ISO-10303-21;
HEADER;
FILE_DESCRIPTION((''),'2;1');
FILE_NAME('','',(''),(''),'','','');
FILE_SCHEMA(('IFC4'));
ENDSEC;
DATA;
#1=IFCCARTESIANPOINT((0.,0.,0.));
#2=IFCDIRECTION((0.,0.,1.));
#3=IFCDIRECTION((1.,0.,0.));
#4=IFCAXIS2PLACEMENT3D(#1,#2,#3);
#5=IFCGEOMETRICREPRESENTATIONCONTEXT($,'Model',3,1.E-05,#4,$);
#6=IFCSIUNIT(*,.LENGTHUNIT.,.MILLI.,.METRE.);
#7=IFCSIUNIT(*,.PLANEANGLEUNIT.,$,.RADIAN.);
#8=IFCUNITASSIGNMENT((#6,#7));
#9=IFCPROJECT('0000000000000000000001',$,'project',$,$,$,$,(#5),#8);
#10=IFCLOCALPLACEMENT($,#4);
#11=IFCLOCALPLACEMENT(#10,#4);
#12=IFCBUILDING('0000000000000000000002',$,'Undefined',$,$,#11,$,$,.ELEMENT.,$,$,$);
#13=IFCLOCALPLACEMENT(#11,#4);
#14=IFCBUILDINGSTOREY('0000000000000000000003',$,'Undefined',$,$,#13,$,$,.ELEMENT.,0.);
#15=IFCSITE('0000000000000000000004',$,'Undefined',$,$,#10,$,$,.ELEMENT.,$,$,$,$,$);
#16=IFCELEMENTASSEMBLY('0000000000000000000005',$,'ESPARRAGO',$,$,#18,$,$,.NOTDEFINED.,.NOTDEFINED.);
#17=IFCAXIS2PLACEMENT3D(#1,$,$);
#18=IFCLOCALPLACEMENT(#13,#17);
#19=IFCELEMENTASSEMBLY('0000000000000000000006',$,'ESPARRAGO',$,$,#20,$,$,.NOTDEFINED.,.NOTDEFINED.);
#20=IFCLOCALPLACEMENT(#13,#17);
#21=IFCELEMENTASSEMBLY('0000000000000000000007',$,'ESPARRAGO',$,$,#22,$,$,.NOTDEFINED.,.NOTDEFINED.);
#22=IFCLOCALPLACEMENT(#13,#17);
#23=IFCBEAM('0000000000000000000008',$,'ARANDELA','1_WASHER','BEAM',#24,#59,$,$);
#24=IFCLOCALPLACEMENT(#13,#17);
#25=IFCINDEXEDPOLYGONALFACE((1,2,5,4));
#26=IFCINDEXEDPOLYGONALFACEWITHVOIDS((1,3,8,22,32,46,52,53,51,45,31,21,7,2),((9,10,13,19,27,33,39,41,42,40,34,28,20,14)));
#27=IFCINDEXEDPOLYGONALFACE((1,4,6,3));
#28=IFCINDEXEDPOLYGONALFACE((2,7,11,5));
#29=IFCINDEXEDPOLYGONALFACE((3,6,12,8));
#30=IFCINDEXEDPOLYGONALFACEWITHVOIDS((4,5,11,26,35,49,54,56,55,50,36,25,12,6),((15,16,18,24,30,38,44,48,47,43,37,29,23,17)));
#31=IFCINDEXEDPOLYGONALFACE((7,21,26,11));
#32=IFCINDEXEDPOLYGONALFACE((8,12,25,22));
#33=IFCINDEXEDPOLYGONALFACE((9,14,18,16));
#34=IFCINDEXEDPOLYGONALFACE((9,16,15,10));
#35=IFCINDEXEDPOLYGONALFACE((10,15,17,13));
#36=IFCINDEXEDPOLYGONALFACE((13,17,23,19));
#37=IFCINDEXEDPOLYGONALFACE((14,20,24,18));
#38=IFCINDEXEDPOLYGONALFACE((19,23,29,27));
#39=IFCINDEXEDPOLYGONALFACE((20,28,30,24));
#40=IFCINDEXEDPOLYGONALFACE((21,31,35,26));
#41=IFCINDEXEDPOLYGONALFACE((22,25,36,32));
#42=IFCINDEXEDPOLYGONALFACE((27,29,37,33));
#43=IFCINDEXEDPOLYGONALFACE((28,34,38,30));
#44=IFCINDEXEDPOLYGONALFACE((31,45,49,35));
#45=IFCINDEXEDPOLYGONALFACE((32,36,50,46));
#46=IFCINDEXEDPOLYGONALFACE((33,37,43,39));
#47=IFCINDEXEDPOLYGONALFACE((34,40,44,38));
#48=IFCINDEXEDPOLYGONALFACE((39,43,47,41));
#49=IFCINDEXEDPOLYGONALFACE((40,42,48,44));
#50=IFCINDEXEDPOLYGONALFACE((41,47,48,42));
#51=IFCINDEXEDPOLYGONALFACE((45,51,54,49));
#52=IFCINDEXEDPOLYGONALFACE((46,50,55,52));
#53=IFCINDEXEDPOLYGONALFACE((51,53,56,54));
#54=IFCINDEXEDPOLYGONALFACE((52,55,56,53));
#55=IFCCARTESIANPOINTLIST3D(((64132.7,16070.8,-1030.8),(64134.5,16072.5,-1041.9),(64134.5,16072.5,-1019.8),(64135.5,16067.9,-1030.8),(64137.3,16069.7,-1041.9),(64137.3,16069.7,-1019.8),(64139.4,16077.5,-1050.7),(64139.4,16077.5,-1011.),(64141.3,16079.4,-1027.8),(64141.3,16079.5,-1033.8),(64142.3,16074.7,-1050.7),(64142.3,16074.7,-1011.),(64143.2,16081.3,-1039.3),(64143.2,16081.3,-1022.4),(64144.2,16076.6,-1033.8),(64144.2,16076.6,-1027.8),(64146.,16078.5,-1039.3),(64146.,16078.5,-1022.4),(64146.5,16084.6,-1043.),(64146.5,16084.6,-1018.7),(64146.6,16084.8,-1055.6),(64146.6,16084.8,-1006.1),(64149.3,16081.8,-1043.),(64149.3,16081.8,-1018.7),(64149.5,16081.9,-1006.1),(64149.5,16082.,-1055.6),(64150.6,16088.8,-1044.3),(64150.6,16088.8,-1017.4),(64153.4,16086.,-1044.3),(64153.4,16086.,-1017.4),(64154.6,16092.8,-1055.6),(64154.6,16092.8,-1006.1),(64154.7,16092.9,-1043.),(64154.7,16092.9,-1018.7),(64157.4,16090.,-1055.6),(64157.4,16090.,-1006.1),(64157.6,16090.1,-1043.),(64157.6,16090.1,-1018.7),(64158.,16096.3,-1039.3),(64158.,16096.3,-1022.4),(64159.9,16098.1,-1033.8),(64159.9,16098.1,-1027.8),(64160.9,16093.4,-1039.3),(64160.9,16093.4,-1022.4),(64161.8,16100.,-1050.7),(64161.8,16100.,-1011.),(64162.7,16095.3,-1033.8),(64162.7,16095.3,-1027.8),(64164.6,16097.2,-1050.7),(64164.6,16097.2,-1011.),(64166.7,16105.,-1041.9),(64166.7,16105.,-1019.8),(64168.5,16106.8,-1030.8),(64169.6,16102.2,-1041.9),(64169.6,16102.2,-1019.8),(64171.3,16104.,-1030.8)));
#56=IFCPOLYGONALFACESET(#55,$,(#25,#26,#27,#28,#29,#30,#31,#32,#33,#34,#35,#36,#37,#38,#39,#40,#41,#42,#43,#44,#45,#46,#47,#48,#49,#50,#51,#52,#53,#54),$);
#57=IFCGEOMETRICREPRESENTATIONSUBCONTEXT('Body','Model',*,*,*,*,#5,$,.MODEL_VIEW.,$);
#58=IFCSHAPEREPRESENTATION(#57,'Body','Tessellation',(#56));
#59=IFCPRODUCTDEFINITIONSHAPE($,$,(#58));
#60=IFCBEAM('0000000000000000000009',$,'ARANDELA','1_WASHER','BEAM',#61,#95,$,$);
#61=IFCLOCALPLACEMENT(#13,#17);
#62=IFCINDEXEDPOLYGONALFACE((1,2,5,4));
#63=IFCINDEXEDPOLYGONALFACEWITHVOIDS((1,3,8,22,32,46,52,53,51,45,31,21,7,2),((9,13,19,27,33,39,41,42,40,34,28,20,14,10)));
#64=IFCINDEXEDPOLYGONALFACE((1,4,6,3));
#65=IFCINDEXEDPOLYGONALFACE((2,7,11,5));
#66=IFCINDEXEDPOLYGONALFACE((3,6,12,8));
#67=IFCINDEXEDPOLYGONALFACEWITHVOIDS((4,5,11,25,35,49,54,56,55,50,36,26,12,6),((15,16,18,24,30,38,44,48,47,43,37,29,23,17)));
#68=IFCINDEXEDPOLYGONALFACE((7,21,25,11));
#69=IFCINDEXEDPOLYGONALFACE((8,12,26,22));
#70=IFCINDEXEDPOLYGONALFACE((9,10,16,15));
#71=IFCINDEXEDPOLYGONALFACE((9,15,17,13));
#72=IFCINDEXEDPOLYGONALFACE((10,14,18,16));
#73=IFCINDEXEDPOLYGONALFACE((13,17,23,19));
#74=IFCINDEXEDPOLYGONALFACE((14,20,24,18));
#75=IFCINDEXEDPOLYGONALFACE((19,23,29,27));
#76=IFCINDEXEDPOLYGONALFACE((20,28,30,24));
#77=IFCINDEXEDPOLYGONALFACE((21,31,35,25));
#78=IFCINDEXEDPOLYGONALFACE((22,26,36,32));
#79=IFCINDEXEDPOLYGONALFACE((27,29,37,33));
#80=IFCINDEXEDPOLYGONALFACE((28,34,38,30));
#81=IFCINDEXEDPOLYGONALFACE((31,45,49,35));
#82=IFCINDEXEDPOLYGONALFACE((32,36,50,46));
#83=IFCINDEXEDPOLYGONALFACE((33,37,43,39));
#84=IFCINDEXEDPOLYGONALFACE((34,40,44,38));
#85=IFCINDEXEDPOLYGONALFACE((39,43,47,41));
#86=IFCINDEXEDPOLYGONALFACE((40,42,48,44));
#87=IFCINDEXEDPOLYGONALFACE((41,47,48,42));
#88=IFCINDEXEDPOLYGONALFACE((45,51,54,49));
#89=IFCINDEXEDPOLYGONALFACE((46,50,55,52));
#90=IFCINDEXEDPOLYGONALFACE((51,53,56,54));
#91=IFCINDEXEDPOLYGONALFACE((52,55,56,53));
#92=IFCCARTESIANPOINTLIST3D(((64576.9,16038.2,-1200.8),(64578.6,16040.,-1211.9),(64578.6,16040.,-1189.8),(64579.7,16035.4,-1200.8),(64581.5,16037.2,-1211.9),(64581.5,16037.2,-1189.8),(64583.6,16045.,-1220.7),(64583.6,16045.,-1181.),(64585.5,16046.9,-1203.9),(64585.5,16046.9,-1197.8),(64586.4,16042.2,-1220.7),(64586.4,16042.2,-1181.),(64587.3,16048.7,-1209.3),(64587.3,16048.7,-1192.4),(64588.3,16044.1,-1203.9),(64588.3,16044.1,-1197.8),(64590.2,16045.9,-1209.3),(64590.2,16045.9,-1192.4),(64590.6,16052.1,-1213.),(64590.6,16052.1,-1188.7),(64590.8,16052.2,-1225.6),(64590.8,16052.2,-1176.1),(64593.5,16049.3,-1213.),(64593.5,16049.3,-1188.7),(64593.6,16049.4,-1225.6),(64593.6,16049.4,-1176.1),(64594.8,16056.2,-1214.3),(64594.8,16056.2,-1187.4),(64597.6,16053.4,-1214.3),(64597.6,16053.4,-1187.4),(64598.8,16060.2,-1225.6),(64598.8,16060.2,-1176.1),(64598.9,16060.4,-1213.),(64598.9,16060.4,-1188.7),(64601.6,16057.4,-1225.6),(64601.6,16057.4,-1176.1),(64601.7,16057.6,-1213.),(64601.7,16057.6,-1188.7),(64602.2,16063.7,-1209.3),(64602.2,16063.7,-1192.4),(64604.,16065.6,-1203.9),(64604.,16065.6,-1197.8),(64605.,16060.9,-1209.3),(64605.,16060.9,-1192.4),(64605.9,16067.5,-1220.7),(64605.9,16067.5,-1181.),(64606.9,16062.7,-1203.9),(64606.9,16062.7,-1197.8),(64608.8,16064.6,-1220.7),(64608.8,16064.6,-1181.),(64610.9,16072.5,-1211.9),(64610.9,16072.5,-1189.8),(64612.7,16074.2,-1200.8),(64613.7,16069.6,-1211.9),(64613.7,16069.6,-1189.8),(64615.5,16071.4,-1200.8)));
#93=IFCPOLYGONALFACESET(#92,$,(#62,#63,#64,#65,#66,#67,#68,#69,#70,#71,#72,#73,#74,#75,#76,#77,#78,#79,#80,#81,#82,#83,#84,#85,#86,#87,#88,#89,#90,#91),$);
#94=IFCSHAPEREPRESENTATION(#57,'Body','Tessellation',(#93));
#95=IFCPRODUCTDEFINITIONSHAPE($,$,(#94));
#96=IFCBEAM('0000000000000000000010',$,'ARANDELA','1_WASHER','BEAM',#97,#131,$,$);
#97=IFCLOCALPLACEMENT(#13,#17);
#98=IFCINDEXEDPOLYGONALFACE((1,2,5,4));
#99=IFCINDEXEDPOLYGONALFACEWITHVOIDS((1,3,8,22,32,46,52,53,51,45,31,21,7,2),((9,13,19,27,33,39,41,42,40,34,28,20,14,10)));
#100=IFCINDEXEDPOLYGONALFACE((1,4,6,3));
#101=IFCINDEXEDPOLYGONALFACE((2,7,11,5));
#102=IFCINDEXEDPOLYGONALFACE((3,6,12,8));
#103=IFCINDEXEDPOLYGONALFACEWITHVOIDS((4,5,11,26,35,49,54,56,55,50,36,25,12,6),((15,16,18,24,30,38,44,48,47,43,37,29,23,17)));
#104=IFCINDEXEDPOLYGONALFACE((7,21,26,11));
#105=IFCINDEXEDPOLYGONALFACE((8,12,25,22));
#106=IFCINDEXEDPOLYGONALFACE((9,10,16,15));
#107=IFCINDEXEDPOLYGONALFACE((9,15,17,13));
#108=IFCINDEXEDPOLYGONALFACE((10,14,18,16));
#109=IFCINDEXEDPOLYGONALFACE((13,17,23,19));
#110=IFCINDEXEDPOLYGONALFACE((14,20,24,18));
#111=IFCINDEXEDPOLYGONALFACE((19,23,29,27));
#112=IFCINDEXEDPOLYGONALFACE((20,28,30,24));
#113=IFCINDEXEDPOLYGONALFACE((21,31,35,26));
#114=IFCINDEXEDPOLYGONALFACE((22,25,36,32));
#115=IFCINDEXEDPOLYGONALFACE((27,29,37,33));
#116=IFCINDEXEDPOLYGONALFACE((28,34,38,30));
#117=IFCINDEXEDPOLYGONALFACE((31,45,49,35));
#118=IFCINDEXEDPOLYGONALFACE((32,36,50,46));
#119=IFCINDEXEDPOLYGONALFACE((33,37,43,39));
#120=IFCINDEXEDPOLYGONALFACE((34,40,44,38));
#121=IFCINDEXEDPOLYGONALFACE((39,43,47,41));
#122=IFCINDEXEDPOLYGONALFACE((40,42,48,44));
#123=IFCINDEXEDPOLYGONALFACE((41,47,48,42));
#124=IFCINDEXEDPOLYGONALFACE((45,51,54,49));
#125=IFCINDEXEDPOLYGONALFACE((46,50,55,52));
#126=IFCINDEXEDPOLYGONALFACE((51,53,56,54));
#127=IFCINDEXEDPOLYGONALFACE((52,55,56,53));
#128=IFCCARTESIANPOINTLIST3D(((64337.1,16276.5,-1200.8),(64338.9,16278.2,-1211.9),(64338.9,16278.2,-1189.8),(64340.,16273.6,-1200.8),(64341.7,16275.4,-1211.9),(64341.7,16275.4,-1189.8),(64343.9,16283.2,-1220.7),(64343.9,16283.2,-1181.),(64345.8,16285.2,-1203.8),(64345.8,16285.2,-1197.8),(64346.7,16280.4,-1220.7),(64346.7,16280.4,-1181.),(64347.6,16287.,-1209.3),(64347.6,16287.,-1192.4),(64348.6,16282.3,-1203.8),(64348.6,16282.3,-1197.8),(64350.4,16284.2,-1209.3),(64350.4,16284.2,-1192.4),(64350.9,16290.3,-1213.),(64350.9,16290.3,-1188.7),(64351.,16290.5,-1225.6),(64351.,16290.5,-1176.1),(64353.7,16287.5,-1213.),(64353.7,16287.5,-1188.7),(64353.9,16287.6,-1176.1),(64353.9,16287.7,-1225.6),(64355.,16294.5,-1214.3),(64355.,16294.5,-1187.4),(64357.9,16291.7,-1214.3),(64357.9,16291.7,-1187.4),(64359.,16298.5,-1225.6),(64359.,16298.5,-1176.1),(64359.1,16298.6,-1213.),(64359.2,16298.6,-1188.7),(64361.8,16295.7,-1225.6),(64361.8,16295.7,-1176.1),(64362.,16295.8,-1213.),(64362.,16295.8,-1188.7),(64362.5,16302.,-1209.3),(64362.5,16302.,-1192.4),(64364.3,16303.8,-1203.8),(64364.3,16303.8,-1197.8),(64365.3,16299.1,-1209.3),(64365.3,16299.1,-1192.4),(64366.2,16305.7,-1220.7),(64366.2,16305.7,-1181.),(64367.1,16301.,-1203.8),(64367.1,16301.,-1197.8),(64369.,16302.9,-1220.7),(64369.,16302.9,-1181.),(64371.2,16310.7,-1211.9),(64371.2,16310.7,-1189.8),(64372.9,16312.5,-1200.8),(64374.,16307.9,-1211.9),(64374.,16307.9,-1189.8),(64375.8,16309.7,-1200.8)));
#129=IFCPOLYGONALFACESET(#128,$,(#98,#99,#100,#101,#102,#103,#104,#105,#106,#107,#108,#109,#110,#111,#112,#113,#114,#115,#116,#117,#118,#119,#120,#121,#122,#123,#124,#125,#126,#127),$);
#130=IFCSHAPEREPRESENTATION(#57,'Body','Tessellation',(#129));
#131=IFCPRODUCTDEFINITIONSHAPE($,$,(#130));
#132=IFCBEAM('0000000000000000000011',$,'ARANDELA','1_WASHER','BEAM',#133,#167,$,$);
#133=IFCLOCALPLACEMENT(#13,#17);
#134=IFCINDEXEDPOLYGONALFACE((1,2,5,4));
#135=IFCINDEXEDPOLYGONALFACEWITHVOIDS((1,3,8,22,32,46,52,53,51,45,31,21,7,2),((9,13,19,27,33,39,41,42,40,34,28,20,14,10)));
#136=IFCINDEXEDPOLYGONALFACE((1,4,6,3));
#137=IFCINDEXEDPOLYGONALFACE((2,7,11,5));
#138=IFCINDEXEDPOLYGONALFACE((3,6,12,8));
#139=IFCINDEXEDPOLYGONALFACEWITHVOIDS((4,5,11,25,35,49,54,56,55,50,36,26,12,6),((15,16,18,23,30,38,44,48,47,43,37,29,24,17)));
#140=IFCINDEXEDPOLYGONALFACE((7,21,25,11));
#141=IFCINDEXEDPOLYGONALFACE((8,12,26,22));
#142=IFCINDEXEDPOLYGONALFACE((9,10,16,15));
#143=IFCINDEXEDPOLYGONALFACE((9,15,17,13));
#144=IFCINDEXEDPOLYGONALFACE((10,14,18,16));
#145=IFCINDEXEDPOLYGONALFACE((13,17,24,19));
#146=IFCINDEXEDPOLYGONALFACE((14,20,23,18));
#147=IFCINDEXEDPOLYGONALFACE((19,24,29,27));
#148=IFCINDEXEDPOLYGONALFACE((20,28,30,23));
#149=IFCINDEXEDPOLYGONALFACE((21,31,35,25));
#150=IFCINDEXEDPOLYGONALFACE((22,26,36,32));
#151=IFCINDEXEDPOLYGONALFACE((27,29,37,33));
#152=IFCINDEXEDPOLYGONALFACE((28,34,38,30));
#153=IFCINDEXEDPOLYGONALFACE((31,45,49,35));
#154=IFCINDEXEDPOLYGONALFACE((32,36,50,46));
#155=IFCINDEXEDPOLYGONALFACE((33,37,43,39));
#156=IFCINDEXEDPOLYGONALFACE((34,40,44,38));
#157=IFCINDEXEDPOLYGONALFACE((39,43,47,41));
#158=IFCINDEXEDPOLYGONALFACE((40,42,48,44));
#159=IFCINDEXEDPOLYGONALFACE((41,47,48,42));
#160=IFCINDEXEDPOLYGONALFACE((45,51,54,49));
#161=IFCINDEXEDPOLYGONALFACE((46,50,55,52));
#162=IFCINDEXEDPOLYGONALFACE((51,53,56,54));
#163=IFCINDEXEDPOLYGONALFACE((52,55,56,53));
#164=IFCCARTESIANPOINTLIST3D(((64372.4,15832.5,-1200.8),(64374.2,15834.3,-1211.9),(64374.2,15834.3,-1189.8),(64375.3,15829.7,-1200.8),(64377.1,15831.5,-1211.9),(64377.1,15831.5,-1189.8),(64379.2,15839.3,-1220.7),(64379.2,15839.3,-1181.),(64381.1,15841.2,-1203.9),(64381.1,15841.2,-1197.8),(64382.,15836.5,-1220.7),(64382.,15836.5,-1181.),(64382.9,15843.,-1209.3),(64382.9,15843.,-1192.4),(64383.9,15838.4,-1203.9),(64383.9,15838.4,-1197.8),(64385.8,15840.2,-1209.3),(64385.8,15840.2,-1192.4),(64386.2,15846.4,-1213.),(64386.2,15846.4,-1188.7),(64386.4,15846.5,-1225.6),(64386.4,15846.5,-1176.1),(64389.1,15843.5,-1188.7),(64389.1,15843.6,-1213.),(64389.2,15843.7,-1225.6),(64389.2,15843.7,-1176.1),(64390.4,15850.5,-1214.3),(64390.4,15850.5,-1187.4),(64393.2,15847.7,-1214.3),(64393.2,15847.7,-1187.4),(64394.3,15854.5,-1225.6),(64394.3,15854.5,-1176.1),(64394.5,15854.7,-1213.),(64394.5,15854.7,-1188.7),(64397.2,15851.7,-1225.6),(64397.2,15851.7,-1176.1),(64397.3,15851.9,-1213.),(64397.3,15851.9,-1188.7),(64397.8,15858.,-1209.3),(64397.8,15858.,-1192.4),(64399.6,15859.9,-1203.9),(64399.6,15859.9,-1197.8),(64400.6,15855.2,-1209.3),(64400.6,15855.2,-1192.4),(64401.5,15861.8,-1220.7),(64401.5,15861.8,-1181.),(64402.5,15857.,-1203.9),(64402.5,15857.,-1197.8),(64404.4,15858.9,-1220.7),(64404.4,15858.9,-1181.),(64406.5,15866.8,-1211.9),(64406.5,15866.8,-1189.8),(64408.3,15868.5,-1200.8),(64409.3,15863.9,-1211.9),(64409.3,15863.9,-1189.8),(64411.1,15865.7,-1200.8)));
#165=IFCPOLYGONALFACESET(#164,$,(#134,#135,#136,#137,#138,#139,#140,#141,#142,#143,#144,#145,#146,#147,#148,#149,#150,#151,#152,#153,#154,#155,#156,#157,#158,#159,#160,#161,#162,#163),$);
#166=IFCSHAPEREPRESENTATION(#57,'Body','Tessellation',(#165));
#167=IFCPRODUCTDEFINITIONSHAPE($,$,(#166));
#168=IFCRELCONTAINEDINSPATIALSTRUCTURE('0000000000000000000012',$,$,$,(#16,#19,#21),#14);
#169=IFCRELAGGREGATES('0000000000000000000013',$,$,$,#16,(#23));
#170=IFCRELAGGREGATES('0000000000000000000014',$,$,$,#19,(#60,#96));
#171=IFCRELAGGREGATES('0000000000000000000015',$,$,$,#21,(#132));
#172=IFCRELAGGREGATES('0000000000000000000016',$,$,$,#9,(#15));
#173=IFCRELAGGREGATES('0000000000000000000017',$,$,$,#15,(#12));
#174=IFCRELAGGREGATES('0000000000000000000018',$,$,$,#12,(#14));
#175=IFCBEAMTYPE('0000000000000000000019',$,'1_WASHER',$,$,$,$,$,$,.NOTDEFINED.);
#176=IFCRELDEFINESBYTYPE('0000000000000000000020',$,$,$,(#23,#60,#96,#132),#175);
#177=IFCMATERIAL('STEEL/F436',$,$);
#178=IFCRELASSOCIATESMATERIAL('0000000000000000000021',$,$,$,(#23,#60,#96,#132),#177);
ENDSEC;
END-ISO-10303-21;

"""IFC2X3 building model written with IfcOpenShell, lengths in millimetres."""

from ifc_helpers import new_model, si_unit, frame, origin_with_axes, place, context, subcontext, project, spatial, polyline, outline, extrude, material, type_object, element, aggregate, save


model = new_model("IFC2X3")

# Units and contexts
model_context = context("Model", 3, precision=1e-05, world=origin_with_axes())
body_context = subcontext(model_context, "Body", "Model", "MODEL_VIEW")
ifc_project = project(units=[si_unit("LENGTHUNIT", "METRE", prefix="MILLI"), si_unit("PLANEANGLEUNIT", "RADIAN")], contexts=[model_context])

# Site, building, storey
site_placement = place(None, origin_with_axes())
site = spatial("IfcSite", under=ifc_project, at=site_placement, Name="Undefined", CompositionType="ELEMENT")
building_placement = place(site_placement, origin_with_axes())
building = spatial("IfcBuilding", under=site, at=building_placement, Name="Undefined", CompositionType="ELEMENT")
storey_placement = place(building_placement, origin_with_axes())
storey = spatial("IfcBuildingStorey", under=building, at=storey_placement, Name="Undefined", CompositionType="ELEMENT", Elevation=0.0)

# Element assembly
assembly_1_placement = place(storey_placement, origin_with_axes())
assembly_1 = element("IfcElementAssembly", 1, at=assembly_1_placement, inside=storey, Name="ESPARRAGO", AssemblyPlace="NOTDEFINED", PredefinedType="NOTDEFINED")

# Element assembly
assembly_2_placement = place(storey_placement, origin_with_axes())
assembly_2 = element("IfcElementAssembly", 2, at=assembly_2_placement, inside=storey, Name="ESPARRAGO", AssemblyPlace="NOTDEFINED", PredefinedType="NOTDEFINED")

# Element assembly
assembly_3_placement = place(storey_placement, origin_with_axes())
assembly_3 = element("IfcElementAssembly", 3, at=assembly_3_placement, inside=storey, Name="ESPARRAGO", AssemblyPlace="NOTDEFINED", PredefinedType="NOTDEFINED")

# Beams
ifc_material_1 = material(Name="STEEL/F436")
beam_type_1 = type_object("IfcBeamType", Name="1_WASHER", PredefinedType="NOTDEFINED")
beam_1_placement = place(assembly_1_placement, frame((64150.6, 16088.8, -1030.8), z_axis=(0.000061, -0.000061, 1.0), x_axis=(0.709311, -0.704895, -0.000086)))
beam_1 = element("IfcBeam", 4, at=beam_1_placement, type_object=beam_type_1, material=ifc_material_1, Name="ARANDELA", Description="1_WASHER", ObjectType="BEAM", context=body_context, shape_type="SweptSolid", body=[
    extrude(outline(polyline([(-15.8, -19.9), (-22.9, -11.0), (-25.4, 0.0), (-22.9, 11.0), (-15.8, 19.9), (-5.7, 24.8), (5.7, 24.8), (15.8, 19.9), (22.9, 11.0), (25.4, 0.0), (22.9, -11.0), (15.8, -19.9), (5.7, -24.8), (-5.7, -24.8), (-15.8, -19.9)]), holes=[polyline([(-5.9, 12.2), (-10.5, 8.4), (-13.2, 3.0), (-13.2, -3.0), (-10.5, -8.4), (-5.9, -12.2), (0.0, -13.5), (5.9, -12.2), (10.5, -8.4), (13.2, -3.0), (13.2, 3.0), (10.5, 8.4), (5.9, 12.2), (0.0, 13.5), (-5.9, 12.2)])]), frame((4.0, 0.0, 0.0), z_axis=(-1.0, 0.0, 0.0), x_axis=(0.0, -1.0, 0.0)), (0.0, 0.0, 1.0), 4.0),
])
beam_2_placement = place(assembly_2_placement, frame((64594.8, 16056.2, -1200.8), z_axis=(0.000061, -0.000061, 1.0), x_axis=(0.709311, -0.704895, -0.000086)))
beam_2 = element("IfcBeam", 5, at=beam_2_placement, type_object=beam_type_1, material=ifc_material_1, Name="ARANDELA", Description="1_WASHER", ObjectType="BEAM", context=body_context, shape_type="SweptSolid", body=[
    extrude(outline(polyline([(-15.8, -19.9), (-22.9, -11.0), (-25.4, 0.0), (-22.9, 11.0), (-15.8, 19.9), (-5.7, 24.8), (5.7, 24.8), (15.8, 19.9), (22.9, 11.0), (25.4, 0.0), (22.9, -11.0), (15.8, -19.9), (5.7, -24.8), (-5.7, -24.8), (-15.8, -19.9)]), holes=[polyline([(-5.9, 12.2), (-10.5, 8.4), (-13.2, 3.0), (-13.2, -3.0), (-10.5, -8.4), (-5.9, -12.2), (0.0, -13.5), (5.9, -12.2), (10.5, -8.4), (13.2, -3.0), (13.2, 3.0), (10.5, 8.4), (5.9, 12.2), (0.0, 13.5), (-5.9, 12.2)])]), frame((4.0, 0.0, 0.0), z_axis=(-1.0, 0.0, 0.0), x_axis=(0.0, -1.0, 0.0)), (0.0, 0.0, 1.0), 4.0),
])
beam_3_placement = place(assembly_2_placement, frame((64355.0, 16294.5, -1200.8), z_axis=(0.000061, -0.000061, 1.0), x_axis=(0.709311, -0.704895, -0.000086)))
beam_3 = element("IfcBeam", 6, at=beam_3_placement, type_object=beam_type_1, material=ifc_material_1, Name="ARANDELA", Description="1_WASHER", ObjectType="BEAM", context=body_context, shape_type="SweptSolid", body=[
    extrude(outline(polyline([(-15.8, -19.9), (-22.9, -11.0), (-25.4, 0.0), (-22.9, 11.0), (-15.8, 19.9), (-5.7, 24.8), (5.7, 24.8), (15.8, 19.9), (22.9, 11.0), (25.4, 0.0), (22.9, -11.0), (15.8, -19.9), (5.7, -24.8), (-5.7, -24.8), (-15.8, -19.9)]), holes=[polyline([(-5.9, 12.2), (-10.5, 8.4), (-13.2, 3.0), (-13.2, -3.0), (-10.5, -8.4), (-5.9, -12.2), (0.0, -13.5), (5.9, -12.2), (10.5, -8.4), (13.2, -3.0), (13.2, 3.0), (10.5, 8.4), (5.9, 12.2), (0.0, 13.5), (-5.9, 12.2)])]), frame((4.0, 0.0, 0.0), z_axis=(-1.0, 0.0, 0.0), x_axis=(0.0, -1.0, 0.0)), (0.0, 0.0, 1.0), 4.0),
])
beam_4_placement = place(assembly_3_placement, frame((64390.4, 15850.5, -1200.8), z_axis=(0.000061, -0.000061, 1.0), x_axis=(0.709311, -0.704895, -0.000086)))
beam_4 = element("IfcBeam", 7, at=beam_4_placement, type_object=beam_type_1, material=ifc_material_1, Name="ARANDELA", Description="1_WASHER", ObjectType="BEAM", context=body_context, shape_type="SweptSolid", body=[
    extrude(outline(polyline([(-15.8, -19.9), (-22.9, -11.0), (-25.4, 0.0), (-22.9, 11.0), (-15.8, 19.9), (-5.7, 24.8), (5.7, 24.8), (15.8, 19.9), (22.9, 11.0), (25.4, 0.0), (22.9, -11.0), (15.8, -19.9), (5.7, -24.8), (-5.7, -24.8), (-15.8, -19.9)]), holes=[polyline([(-5.9, 12.2), (-10.5, 8.4), (-13.2, 3.0), (-13.2, -3.0), (-10.5, -8.4), (-5.9, -12.2), (0.0, -13.5), (5.9, -12.2), (10.5, -8.4), (13.2, -3.0), (13.2, 3.0), (10.5, 8.4), (5.9, 12.2), (0.0, 13.5), (-5.9, 12.2)])]), frame((4.0, 0.0, 0.0), z_axis=(-1.0, 0.0, 0.0), x_axis=(0.0, -1.0, 0.0)), (0.0, 0.0, 1.0), 4.0),
])
aggregate(assembly_1, [beam_1])
aggregate(assembly_2, [beam_2, beam_3])
aggregate(assembly_3, [beam_4])

save(model, "model.ifc")
